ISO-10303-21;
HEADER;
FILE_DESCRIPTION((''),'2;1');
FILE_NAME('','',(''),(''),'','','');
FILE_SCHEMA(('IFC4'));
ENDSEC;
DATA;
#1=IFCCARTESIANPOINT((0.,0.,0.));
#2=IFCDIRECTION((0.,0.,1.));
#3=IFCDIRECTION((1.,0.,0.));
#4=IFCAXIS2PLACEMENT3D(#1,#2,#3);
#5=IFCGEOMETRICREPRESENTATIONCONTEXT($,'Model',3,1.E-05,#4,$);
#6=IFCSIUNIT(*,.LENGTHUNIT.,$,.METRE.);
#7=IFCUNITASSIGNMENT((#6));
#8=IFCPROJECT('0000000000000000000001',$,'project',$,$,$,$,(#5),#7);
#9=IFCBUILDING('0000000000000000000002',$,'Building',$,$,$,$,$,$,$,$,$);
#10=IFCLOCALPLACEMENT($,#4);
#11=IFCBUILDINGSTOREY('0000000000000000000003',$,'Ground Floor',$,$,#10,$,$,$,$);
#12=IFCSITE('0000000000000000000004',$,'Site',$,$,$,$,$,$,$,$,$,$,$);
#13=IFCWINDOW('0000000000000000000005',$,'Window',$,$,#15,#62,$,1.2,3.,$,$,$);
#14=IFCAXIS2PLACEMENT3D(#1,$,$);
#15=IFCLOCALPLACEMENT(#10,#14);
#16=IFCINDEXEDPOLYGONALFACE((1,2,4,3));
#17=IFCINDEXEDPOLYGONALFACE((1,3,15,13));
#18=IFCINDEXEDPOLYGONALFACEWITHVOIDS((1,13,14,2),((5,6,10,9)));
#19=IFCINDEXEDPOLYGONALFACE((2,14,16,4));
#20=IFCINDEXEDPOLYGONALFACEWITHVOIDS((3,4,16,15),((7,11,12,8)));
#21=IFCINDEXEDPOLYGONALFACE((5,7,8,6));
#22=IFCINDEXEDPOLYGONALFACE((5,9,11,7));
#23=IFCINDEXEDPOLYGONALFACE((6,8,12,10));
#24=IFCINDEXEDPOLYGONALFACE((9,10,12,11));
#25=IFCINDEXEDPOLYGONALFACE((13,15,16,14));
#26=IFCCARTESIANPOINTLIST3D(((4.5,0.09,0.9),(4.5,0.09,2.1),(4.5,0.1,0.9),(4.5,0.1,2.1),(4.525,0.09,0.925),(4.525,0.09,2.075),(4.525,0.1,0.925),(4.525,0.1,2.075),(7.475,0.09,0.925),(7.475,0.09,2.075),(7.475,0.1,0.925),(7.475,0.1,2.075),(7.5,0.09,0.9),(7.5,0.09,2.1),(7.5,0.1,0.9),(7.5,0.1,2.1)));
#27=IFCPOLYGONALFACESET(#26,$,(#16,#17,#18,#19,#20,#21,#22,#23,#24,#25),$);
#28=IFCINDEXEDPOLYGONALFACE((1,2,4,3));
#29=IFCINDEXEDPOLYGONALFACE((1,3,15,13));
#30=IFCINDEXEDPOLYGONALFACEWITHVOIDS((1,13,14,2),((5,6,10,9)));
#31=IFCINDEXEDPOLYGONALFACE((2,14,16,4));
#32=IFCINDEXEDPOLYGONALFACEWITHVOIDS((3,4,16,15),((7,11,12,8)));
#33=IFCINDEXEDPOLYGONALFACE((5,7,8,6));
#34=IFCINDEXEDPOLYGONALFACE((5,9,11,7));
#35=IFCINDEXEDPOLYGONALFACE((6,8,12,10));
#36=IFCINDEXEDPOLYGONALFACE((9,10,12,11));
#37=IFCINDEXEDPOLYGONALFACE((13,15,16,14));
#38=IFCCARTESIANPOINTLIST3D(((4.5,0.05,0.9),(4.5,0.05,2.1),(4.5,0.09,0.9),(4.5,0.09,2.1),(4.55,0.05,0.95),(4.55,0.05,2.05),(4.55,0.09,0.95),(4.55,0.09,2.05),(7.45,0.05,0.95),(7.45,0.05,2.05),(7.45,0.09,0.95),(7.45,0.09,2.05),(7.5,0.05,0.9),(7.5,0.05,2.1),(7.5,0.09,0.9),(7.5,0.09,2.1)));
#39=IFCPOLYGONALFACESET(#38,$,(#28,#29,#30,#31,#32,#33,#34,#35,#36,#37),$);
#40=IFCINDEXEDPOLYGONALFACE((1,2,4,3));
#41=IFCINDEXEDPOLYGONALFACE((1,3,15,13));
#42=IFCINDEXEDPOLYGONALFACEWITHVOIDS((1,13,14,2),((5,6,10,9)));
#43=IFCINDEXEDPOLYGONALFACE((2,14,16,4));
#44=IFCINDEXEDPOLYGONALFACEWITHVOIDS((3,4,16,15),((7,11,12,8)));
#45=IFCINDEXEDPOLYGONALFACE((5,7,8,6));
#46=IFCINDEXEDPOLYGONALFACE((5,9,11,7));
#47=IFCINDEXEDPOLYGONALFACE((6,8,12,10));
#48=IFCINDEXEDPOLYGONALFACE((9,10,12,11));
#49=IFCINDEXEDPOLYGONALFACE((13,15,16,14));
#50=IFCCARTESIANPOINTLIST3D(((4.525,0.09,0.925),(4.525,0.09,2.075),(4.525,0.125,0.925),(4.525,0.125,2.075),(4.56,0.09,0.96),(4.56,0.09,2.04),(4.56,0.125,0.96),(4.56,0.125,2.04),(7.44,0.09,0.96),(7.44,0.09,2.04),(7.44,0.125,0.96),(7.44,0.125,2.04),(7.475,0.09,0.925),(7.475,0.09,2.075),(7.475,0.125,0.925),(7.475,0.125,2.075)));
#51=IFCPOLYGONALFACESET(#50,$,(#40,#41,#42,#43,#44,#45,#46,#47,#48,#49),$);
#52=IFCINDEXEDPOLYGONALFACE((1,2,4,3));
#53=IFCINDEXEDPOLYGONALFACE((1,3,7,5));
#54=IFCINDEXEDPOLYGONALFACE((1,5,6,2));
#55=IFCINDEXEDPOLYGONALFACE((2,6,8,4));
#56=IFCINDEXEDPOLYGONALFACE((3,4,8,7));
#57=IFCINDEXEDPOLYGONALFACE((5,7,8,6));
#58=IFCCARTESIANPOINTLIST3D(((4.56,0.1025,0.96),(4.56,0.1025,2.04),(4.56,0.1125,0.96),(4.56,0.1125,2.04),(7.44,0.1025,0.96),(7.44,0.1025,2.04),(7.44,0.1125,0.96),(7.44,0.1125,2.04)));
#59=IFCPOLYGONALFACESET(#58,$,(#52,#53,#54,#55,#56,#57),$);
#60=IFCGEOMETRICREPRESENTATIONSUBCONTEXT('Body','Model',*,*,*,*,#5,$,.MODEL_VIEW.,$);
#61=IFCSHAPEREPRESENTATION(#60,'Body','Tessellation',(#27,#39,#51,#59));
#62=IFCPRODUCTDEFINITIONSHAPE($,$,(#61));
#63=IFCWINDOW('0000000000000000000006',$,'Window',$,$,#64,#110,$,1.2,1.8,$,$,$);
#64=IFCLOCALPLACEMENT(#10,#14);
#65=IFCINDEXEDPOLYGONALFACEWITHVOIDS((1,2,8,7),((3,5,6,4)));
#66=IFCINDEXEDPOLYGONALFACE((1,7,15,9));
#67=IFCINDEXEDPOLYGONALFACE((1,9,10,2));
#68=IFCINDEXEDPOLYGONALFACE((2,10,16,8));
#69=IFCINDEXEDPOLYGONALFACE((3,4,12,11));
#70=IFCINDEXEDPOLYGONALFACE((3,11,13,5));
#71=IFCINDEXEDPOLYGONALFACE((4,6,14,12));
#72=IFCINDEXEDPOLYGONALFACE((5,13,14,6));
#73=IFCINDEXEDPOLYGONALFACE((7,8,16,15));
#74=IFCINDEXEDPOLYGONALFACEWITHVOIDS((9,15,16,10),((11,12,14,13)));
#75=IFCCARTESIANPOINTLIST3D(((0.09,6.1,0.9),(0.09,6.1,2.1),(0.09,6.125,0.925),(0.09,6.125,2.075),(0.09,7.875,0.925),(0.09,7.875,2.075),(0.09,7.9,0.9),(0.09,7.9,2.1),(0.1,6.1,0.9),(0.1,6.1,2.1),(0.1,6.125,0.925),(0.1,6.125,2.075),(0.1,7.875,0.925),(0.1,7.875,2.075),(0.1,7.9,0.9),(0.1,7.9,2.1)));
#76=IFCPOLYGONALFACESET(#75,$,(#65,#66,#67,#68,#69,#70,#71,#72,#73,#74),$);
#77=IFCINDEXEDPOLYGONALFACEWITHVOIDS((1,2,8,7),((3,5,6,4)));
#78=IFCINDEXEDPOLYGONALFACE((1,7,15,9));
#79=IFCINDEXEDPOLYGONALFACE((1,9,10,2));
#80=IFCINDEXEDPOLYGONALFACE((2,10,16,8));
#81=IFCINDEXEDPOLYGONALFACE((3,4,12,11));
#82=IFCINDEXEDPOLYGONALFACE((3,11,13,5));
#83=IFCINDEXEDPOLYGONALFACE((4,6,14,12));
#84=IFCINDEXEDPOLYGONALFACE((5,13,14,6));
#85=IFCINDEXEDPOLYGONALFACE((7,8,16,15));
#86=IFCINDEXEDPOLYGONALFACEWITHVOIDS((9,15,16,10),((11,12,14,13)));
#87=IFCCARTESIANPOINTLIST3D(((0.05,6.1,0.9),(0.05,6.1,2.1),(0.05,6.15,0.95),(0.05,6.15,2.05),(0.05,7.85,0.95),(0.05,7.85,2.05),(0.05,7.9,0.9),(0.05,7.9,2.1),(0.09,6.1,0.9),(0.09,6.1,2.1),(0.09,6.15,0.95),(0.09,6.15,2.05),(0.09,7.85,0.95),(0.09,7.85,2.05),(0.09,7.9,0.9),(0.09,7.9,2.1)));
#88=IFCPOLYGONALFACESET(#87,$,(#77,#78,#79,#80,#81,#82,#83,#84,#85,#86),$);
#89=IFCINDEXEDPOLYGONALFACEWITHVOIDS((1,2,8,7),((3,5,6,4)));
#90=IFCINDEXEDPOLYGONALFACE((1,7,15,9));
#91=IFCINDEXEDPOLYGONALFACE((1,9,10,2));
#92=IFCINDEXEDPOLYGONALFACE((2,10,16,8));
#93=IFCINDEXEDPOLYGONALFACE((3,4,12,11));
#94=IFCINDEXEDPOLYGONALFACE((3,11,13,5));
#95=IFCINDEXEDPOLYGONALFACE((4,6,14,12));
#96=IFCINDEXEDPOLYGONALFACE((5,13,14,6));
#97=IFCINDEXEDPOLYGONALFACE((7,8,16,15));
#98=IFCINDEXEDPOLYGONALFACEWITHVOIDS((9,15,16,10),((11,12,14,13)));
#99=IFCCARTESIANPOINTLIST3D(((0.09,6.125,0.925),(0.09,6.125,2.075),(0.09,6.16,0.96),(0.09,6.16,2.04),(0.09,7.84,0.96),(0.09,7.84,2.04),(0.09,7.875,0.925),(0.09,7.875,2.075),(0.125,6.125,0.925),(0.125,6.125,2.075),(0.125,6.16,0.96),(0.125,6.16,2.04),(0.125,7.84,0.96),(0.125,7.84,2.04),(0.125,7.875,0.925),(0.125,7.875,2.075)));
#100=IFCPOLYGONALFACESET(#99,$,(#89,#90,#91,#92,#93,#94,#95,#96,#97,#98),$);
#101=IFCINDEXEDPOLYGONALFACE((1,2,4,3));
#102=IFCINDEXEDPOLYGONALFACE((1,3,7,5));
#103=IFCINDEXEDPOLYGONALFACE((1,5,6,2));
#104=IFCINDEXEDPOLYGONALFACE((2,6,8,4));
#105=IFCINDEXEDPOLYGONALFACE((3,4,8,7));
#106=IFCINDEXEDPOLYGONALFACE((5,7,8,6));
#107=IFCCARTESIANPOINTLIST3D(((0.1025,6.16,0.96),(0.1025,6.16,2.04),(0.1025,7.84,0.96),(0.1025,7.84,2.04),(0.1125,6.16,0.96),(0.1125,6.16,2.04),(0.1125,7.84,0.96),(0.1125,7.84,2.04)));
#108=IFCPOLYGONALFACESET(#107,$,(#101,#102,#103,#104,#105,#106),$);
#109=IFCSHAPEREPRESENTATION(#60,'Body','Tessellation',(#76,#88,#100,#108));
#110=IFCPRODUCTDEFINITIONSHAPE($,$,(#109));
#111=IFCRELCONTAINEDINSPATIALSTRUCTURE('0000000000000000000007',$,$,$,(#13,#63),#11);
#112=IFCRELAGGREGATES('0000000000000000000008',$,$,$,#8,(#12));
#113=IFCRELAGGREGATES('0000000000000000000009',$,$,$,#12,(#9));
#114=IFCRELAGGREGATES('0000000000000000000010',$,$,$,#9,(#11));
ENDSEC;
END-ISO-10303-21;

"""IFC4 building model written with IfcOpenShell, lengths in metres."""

from ifc_helpers import new_model, si_unit, frame, origin_with_axes, place, context, subcontext, project, spatial, line, indexed_curve, outline, extrude, element, save


model = new_model("IFC4")

# Units and contexts
model_context = context("Model", 3, precision=1e-05, world=origin_with_axes())
body_context = subcontext(model_context, "Body", "Model", "MODEL_VIEW")
ifc_project = project(units=[si_unit("LENGTHUNIT", "METRE")], contexts=[model_context])

# Site, building, storey
site = spatial("IfcSite", under=ifc_project, Name="Site")
building = spatial("IfcBuilding", under=site, Name="Building")
storey_placement = place(None, origin_with_axes())
storey = spatial("IfcBuildingStorey", under=building, at=storey_placement, Name="Ground Floor")

# Windows
window_1_placement = place(storey_placement, frame((4.5, 0.0, 0.9), z_axis=(0.0, 0.0, 1.0), x_axis=(1.0, 0.0, 0.0)))
element("IfcWindow", 1, at=window_1_placement, inside=storey, Name="Window", OverallHeight=1.2, OverallWidth=3.0, context=body_context, shape_type="SweptSolid", body=[
    extrude(outline(indexed_curve([(0.0, 0.0), (3.0, 0.0), (3.0, 1.2), (0.0, 1.2)], segments=[line(1, 2, 3, 4, 1)]), holes=[indexed_curve([(0.025, 0.025), (2.975, 0.025), (2.975, 1.175), (0.025, 1.175)], segments=[line(1, 2, 3, 4, 1)])]), frame((0.0, 0.09, 0.0), z_axis=(0.0, -1.0, 0.0), x_axis=(1.0, 0.0, 0.0)), (0.0, 0.0, -1.0), 0.01),
    extrude(outline(indexed_curve([(0.0, 0.0), (3.0, 0.0), (3.0, 1.2), (0.0, 1.2)], segments=[line(1, 2, 3, 4, 1)]), holes=[indexed_curve([(0.05, 0.05), (2.95, 0.05), (2.95, 1.15), (0.05, 1.15)], segments=[line(1, 2, 3, 4, 1)])]), frame((0.0, 0.05, 0.0), z_axis=(0.0, -1.0, 0.0), x_axis=(1.0, 0.0, 0.0)), (0.0, 0.0, -1.0), 0.04),
    extrude(outline(indexed_curve([(0.0, 0.0), (2.95, 0.0), (2.95, 1.15), (0.0, 1.15)], segments=[line(1, 2, 3, 4, 1)]), holes=[indexed_curve([(0.035, 0.035), (2.915, 0.035), (2.915, 1.115), (0.035, 1.115)], segments=[line(1, 2, 3, 4, 1)])]), frame((0.025, 0.09, 0.025), z_axis=(0.0, -1.0, 0.0), x_axis=(1.0, 0.0, 0.0)), (0.0, 0.0, -1.0), 0.035),
    extrude(outline(indexed_curve([(0.035, 0.035), (2.915, 0.035), (2.915, 1.115), (0.035, 1.115)], segments=[line(1, 2, 3, 4, 1)])), frame((0.025, 0.1025, 0.025), z_axis=(0.0, -1.0, 0.0), x_axis=(1.0, 0.0, 0.0)), (0.0, 0.0, -1.0), 0.01),
])
window_2_placement = place(storey_placement, frame((0.0, 7.9, 0.9), z_axis=(0.0, 0.0, 1.0), x_axis=(0.0, -1.0, 0.0)))
element("IfcWindow", 2, at=window_2_placement, inside=storey, Name="Window", OverallHeight=1.2, OverallWidth=1.8, context=body_context, shape_type="SweptSolid", body=[
    extrude(outline(indexed_curve([(0.0, 0.0), (1.8, 0.0), (1.8, 1.2), (0.0, 1.2)], segments=[line(1, 2, 3, 4, 1)]), holes=[indexed_curve([(0.025, 0.025), (1.775, 0.025), (1.775, 1.175), (0.025, 1.175)], segments=[line(1, 2, 3, 4, 1)])]), frame((0.0, 0.09, 0.0), z_axis=(0.0, -1.0, 0.0), x_axis=(1.0, 0.0, 0.0)), (0.0, 0.0, -1.0), 0.01),
    extrude(outline(indexed_curve([(0.0, 0.0), (1.8, 0.0), (1.8, 1.2), (0.0, 1.2)], segments=[line(1, 2, 3, 4, 1)]), holes=[indexed_curve([(0.05, 0.05), (1.75, 0.05), (1.75, 1.15), (0.05, 1.15)], segments=[line(1, 2, 3, 4, 1)])]), frame((0.0, 0.05, 0.0), z_axis=(0.0, -1.0, 0.0), x_axis=(1.0, 0.0, 0.0)), (0.0, 0.0, -1.0), 0.04),
    extrude(outline(indexed_curve([(0.0, 0.0), (1.75, 0.0), (1.75, 1.15), (0.0, 1.15)], segments=[line(1, 2, 3, 4, 1)]), holes=[indexed_curve([(0.035, 0.035), (1.715, 0.035), (1.715, 1.115), (0.035, 1.115)], segments=[line(1, 2, 3, 4, 1)])]), frame((0.025, 0.09, 0.025), z_axis=(0.0, -1.0, 0.0), x_axis=(1.0, 0.0, 0.0)), (0.0, 0.0, -1.0), 0.035),
    extrude(outline(indexed_curve([(0.035, 0.035), (1.715, 0.035), (1.715, 1.115), (0.035, 1.115)], segments=[line(1, 2, 3, 4, 1)])), frame((0.025, 0.1025, 0.025), z_axis=(0.0, -1.0, 0.0), x_axis=(1.0, 0.0, 0.0)), (0.0, 0.0, -1.0), 0.01),
])

save(model, "model.ifc")
